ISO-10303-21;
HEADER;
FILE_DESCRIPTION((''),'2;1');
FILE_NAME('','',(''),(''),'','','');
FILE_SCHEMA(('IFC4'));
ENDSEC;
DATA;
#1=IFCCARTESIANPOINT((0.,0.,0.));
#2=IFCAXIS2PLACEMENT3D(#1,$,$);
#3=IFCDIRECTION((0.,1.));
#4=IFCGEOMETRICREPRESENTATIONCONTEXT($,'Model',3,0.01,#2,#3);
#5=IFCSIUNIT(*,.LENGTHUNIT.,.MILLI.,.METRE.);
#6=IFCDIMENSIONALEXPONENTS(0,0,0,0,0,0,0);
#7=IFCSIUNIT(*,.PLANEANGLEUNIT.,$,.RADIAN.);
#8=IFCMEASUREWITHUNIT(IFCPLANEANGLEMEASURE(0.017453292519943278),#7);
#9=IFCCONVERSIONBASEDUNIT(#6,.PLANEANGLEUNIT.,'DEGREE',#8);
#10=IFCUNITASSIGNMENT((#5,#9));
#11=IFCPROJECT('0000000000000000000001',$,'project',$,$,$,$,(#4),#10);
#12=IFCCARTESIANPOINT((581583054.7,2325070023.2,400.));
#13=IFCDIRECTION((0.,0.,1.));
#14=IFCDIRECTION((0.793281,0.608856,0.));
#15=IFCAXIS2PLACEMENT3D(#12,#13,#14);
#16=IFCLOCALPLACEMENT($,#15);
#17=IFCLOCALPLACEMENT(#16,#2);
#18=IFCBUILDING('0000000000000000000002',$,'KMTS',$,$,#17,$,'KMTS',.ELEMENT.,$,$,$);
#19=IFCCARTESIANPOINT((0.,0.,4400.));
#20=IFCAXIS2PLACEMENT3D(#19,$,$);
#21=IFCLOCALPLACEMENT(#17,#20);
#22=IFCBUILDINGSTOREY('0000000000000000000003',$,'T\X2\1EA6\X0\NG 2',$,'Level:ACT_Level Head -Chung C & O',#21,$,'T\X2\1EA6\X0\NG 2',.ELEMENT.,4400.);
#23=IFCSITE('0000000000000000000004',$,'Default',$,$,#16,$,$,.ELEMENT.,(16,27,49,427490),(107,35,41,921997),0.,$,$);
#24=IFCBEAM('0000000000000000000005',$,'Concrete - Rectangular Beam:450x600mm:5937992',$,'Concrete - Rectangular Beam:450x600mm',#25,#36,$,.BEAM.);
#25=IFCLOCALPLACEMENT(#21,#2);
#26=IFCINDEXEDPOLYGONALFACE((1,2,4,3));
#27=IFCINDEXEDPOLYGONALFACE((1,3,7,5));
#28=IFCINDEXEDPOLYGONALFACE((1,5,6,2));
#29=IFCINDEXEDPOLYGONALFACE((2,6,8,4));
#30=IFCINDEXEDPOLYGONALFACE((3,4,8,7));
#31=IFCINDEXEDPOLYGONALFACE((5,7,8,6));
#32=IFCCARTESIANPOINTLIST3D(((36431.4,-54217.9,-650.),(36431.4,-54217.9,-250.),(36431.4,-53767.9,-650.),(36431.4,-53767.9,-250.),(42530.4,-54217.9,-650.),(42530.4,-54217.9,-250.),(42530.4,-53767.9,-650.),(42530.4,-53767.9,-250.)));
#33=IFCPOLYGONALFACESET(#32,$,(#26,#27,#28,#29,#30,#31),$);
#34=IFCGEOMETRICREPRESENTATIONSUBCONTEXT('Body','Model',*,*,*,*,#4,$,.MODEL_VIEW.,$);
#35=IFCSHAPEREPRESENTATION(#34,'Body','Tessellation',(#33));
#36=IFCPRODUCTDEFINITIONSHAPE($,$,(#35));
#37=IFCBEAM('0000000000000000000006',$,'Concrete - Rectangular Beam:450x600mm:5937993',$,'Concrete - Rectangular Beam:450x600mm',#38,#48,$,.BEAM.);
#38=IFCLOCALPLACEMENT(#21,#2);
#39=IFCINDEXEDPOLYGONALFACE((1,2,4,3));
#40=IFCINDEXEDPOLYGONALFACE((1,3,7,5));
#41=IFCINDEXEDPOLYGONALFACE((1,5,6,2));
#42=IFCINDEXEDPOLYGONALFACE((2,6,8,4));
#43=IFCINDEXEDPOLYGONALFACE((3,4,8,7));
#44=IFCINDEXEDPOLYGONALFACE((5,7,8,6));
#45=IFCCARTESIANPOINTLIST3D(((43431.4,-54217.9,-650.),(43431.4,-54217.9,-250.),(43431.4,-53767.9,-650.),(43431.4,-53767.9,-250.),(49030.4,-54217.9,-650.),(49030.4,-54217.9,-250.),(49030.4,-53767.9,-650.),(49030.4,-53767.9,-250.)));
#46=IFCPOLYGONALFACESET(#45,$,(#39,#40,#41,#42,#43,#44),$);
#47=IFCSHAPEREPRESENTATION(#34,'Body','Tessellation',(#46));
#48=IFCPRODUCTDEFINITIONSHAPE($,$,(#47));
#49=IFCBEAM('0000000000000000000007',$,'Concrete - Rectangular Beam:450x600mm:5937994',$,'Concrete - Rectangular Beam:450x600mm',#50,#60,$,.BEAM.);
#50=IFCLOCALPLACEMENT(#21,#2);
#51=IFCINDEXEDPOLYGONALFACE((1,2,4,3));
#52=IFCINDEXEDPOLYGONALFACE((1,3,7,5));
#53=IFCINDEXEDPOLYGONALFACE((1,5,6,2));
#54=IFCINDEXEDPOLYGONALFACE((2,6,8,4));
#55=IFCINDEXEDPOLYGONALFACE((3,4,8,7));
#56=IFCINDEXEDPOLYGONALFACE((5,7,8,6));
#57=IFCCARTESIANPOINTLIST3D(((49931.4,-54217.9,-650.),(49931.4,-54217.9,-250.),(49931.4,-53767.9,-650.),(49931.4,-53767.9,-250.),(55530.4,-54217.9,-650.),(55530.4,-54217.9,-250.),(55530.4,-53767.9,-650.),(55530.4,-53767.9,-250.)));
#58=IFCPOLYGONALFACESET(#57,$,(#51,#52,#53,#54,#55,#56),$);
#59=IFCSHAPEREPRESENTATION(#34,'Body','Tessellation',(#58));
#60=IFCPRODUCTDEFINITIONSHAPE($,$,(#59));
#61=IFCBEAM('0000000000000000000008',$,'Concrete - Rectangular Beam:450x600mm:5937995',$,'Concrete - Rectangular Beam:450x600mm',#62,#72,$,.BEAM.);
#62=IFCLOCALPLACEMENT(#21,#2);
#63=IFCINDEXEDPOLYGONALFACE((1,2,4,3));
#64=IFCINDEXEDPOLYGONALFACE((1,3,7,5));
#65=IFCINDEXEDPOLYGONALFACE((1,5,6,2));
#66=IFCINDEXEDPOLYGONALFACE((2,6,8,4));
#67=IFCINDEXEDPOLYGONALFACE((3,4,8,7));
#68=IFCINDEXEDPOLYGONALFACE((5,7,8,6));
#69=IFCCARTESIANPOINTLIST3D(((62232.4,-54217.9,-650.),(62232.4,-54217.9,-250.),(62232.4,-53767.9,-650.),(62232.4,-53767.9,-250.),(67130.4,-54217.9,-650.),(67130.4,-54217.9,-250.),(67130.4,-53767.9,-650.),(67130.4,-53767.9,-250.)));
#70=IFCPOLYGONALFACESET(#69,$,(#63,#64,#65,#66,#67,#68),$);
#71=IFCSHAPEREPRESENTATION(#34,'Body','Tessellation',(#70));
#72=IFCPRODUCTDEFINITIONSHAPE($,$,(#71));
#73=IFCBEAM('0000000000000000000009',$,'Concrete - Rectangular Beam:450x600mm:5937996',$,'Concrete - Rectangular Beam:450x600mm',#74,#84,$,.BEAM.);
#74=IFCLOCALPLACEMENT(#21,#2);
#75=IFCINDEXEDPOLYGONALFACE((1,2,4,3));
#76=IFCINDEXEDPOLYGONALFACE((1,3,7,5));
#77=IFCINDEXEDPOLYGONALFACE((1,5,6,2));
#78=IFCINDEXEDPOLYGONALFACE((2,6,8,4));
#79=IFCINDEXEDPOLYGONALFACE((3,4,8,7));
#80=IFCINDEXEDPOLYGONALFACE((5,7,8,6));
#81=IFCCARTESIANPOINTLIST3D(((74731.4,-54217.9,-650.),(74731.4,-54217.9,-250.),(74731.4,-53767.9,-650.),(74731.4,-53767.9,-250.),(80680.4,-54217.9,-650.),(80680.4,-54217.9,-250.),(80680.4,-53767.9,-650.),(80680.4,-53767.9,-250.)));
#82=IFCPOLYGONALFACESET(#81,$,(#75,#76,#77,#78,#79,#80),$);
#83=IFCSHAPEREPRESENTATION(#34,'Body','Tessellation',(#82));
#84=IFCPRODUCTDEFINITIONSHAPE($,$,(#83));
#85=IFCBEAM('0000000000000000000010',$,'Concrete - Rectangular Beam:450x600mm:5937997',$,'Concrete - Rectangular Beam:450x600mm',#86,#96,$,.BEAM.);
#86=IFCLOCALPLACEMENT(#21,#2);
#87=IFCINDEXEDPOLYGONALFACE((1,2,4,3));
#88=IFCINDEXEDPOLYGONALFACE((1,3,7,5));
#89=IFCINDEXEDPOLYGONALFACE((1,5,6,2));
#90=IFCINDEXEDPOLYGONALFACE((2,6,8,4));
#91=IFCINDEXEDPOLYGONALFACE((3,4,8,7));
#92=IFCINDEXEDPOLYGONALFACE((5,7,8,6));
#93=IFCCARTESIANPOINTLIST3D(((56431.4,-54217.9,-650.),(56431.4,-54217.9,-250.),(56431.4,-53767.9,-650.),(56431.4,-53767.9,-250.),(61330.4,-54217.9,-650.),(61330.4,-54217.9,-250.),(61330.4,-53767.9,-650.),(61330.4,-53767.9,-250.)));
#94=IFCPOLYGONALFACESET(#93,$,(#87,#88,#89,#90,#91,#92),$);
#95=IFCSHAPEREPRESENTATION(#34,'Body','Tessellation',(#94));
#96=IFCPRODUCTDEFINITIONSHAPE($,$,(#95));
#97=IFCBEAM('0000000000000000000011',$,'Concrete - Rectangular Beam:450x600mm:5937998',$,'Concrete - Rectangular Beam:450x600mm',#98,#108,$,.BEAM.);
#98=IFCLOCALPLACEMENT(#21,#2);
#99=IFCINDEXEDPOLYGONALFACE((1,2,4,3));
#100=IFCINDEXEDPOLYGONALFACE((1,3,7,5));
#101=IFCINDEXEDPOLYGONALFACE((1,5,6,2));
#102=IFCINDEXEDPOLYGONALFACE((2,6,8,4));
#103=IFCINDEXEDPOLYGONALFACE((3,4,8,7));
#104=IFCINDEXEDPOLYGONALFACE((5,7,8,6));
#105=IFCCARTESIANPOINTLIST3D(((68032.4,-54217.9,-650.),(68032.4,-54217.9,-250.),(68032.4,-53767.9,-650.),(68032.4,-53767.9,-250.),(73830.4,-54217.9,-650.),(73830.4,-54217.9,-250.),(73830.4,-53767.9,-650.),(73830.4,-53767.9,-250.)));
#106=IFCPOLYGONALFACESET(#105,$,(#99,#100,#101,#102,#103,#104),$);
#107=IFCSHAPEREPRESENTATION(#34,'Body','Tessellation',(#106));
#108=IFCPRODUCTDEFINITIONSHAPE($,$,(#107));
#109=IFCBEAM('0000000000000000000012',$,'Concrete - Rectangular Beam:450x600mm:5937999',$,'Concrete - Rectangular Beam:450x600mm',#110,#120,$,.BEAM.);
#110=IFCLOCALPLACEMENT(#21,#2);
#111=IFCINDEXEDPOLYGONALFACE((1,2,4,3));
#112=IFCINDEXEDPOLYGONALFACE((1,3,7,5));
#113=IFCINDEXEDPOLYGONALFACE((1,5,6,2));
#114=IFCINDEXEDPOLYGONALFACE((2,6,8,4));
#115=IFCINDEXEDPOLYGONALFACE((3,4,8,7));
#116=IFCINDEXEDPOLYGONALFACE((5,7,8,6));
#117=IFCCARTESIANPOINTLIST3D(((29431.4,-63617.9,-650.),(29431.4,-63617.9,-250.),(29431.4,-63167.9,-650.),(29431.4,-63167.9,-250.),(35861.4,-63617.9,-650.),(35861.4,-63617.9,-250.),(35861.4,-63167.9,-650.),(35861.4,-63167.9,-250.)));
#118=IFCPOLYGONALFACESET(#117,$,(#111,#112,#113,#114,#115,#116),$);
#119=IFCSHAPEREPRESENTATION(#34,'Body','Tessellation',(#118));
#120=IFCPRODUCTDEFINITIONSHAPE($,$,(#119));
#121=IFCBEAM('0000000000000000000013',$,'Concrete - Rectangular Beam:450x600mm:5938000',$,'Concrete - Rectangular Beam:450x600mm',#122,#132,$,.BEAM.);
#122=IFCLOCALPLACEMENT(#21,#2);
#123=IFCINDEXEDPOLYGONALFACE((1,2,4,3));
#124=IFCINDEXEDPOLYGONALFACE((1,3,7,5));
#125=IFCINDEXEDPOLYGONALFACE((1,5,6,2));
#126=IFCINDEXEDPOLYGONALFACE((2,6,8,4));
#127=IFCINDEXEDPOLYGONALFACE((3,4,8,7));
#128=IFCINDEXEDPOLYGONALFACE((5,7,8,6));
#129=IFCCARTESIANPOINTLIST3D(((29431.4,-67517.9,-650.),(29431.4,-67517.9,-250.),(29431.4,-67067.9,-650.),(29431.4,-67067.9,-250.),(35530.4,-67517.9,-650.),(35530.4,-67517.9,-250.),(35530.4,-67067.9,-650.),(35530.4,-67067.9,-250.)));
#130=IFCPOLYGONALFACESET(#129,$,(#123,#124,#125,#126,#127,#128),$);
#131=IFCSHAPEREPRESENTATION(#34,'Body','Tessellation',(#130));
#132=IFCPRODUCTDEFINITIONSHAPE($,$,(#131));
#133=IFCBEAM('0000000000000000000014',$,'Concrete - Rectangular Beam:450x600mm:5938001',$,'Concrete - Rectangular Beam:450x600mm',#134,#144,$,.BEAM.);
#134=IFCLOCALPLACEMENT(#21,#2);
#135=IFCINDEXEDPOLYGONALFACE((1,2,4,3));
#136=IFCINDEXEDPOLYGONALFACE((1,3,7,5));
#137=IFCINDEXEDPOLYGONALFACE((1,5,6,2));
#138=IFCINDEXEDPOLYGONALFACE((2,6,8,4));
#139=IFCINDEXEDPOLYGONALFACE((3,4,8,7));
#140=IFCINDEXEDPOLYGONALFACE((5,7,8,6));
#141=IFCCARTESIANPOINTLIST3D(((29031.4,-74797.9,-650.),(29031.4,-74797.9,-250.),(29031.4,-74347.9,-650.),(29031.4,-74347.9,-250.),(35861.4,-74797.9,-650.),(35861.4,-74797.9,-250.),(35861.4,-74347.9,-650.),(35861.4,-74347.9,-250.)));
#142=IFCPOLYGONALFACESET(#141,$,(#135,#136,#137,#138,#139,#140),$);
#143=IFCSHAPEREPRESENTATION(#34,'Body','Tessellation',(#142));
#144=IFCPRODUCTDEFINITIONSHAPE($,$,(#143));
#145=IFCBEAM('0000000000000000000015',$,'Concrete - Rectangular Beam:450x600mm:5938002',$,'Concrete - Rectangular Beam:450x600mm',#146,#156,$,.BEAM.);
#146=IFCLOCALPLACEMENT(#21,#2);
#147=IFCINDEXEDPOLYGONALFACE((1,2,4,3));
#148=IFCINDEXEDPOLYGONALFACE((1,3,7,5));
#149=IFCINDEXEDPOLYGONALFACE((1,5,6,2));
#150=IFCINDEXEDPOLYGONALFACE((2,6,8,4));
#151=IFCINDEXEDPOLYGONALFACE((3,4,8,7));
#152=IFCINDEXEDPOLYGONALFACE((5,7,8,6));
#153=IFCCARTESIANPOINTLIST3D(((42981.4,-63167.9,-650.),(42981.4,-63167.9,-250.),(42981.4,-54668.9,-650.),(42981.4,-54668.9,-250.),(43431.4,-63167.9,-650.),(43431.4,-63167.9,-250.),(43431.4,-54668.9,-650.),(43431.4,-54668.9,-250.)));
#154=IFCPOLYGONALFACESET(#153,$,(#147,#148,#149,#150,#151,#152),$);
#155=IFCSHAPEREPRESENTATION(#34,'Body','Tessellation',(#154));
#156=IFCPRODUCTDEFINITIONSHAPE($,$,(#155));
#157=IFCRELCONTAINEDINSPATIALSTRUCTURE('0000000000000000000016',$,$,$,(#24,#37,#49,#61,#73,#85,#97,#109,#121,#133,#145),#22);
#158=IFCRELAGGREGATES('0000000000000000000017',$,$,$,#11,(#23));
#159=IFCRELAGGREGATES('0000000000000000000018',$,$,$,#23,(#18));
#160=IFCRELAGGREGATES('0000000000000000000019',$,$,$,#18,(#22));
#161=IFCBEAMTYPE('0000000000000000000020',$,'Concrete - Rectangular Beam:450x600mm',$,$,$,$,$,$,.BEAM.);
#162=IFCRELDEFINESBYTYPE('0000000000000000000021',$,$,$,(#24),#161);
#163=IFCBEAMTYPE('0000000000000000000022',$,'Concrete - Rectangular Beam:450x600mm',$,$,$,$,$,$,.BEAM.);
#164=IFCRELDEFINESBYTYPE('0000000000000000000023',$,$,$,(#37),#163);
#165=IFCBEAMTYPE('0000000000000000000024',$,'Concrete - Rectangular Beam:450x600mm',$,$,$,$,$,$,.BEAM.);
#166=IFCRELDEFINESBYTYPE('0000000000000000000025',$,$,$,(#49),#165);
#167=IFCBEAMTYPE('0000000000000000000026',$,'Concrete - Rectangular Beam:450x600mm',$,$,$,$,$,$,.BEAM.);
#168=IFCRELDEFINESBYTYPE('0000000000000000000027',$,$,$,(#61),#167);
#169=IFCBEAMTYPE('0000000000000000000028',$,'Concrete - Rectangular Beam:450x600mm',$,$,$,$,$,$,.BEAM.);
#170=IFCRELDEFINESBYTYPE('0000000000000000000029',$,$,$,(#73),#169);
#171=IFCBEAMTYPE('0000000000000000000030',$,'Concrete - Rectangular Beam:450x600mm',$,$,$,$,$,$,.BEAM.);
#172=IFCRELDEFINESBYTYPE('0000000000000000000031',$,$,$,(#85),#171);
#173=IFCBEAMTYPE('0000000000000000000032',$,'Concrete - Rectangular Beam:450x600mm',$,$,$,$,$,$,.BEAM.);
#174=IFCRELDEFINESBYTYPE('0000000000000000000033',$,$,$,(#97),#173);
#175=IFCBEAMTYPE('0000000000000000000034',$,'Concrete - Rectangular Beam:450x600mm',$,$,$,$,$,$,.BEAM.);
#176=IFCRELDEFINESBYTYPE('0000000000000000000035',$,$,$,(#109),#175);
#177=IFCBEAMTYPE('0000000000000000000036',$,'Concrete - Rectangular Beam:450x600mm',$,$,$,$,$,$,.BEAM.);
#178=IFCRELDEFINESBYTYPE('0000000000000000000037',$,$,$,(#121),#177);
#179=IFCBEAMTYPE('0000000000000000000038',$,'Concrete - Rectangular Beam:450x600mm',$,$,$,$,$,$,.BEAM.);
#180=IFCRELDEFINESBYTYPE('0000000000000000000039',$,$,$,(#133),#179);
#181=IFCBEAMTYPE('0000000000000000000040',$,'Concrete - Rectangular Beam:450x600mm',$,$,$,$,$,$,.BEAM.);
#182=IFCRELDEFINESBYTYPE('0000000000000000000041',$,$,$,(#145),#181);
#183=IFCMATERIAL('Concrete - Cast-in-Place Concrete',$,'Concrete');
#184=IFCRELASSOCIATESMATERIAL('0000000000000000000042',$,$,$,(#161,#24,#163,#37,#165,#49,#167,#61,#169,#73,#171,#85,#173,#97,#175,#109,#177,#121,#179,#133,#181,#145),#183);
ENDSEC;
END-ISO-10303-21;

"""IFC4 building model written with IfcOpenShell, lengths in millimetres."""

from ifc_helpers import new_model, entity, si_unit, converted_unit, direction, frame, origin, place, context, subcontext, project, spatial, indexed_curve, outline, extrude, source, transform, mapped, material, type_object, type_shapes, element, save


model = new_model("IFC4")

# Units and contexts
model_context = context("Model", 3, precision=0.01, world=origin(), true_north=direction((0.0, 1.0)))
body_context = subcontext(model_context, "Body", "Model", "MODEL_VIEW")
ifc_project = project(units=[si_unit("LENGTHUNIT", "METRE", prefix="MILLI"), converted_unit("PLANEANGLEUNIT", "DEGREE", entity("IfcPlaneAngleMeasure", 0.017453292519943278), si_unit("PLANEANGLEUNIT", "RADIAN"), dimensions=[0, 0, 0, 0, 0, 0, 0])], contexts=[model_context])

# Site, building, storey
site_placement = place(None, frame((581583054.7, 2325070023.2, 400.0), z_axis=(0.0, 0.0, 1.0), x_axis=(0.793281, 0.608856, 0.0)))
site = spatial("IfcSite", under=ifc_project, at=site_placement, Name="Default", CompositionType="ELEMENT", RefLatitude=(16, 27, 49, 427490), RefLongitude=(107, 35, 41, 921997), RefElevation=0.0)
building_placement = place(site_placement, origin())
building = spatial("IfcBuilding", under=site, at=building_placement, Name="KMTS", LongName="KMTS", CompositionType="ELEMENT")
storey_placement = place(building_placement, frame((0.0, 0.0, 4400.0)))
storey = spatial("IfcBuildingStorey", under=building, at=storey_placement, Name="TẦNG 2", ObjectType="Level:ACT_Level Head -Chung C & O", LongName="TẦNG 2", CompositionType="ELEMENT", Elevation=4400.0)

# Beams
ifc_material = material(Name="Concrete - Cast-in-Place Concrete", Category="Concrete")
beam_type_1 = type_object("IfcBeamType", Name="Concrete - Rectangular Beam:450x600mm", PredefinedType="BEAM", material=ifc_material)
shared_shape_1 = source(origin(), body_context, "Body", "SweptSolid", [
    extrude(outline(indexed_curve([(-200.0, -225.0), (200.0, -225.0), (200.0, 225.0), (-200.0, 225.0), (-200.0, -225.0)], self_intersect=False)), frame((36431.4, -53992.9, 3950.0), z_axis=(1.0, 0.0, 0.0), x_axis=(0.0, 0.0, -1.0)), (0.0, 0.0, 1.0), 6099.0),
])
type_shapes(beam_type_1, [shared_shape_1])
beam_1_placement = place(storey_placement, frame((0.0, 0.0, -4400.0)))
element("IfcBeam", 1, at=beam_1_placement, inside=storey, type_object=beam_type_1, material=ifc_material, Name="Concrete - Rectangular Beam:450x600mm:5937992", ObjectType="Concrete - Rectangular Beam:450x600mm", PredefinedType="BEAM", context=body_context, shape_type="MappedRepresentation", body=[
    mapped(shared_shape_1, transform((0.0, 0.0, 0.0), scale=1.0)),
])
beam_type_2 = type_object("IfcBeamType", Name="Concrete - Rectangular Beam:450x600mm", PredefinedType="BEAM", material=ifc_material)
shared_shape_2 = source(origin(), body_context, "Body", "SweptSolid", [
    extrude(outline(indexed_curve([(-200.0, -225.0), (200.0, -225.0), (200.0, 225.0), (-200.0, 225.0), (-200.0, -225.0)], self_intersect=False)), frame((43431.4, -53992.9, 3950.0), z_axis=(1.0, 0.0, 0.0), x_axis=(0.0, 0.0, -1.0)), (0.0, 0.0, 1.0), 5599.0),
])
type_shapes(beam_type_2, [shared_shape_2])
beam_2_placement = place(storey_placement, frame((0.0, 0.0, -4400.0)))
element("IfcBeam", 2, at=beam_2_placement, inside=storey, type_object=beam_type_2, material=ifc_material, Name="Concrete - Rectangular Beam:450x600mm:5937993", ObjectType="Concrete - Rectangular Beam:450x600mm", PredefinedType="BEAM", context=body_context, shape_type="MappedRepresentation", body=[
    mapped(shared_shape_2, transform((0.0, 0.0, 0.0), scale=1.0)),
])
beam_type_3 = type_object("IfcBeamType", Name="Concrete - Rectangular Beam:450x600mm", PredefinedType="BEAM", material=ifc_material)
shared_shape_3 = source(origin(), body_context, "Body", "SweptSolid", [
    extrude(outline(indexed_curve([(-200.0, -225.0), (200.0, -225.0), (200.0, 225.0), (-200.0, 225.0), (-200.0, -225.0)], self_intersect=False)), frame((49931.4, -53992.9, 3950.0), z_axis=(1.0, 0.0, 0.0), x_axis=(0.0, 0.0, -1.0)), (0.0, 0.0, 1.0), 5599.0),
])
type_shapes(beam_type_3, [shared_shape_3])
beam_3_placement = place(storey_placement, frame((0.0, 0.0, -4400.0)))
element("IfcBeam", 3, at=beam_3_placement, inside=storey, type_object=beam_type_3, material=ifc_material, Name="Concrete - Rectangular Beam:450x600mm:5937994", ObjectType="Concrete - Rectangular Beam:450x600mm", PredefinedType="BEAM", context=body_context, shape_type="MappedRepresentation", body=[
    mapped(shared_shape_3, transform((0.0, 0.0, 0.0), scale=1.0)),
])
beam_type_4 = type_object("IfcBeamType", Name="Concrete - Rectangular Beam:450x600mm", PredefinedType="BEAM", material=ifc_material)
shared_shape_4 = source(origin(), body_context, "Body", "SweptSolid", [
    extrude(outline(indexed_curve([(-200.0, -225.0), (200.0, -225.0), (200.0, 225.0), (-200.0, 225.0), (-200.0, -225.0)], self_intersect=False)), frame((62232.4, -53992.9, 3950.0), z_axis=(1.0, 0.0, 0.0), x_axis=(0.0, 0.0, -1.0)), (0.0, 0.0, 1.0), 4898.0),
])
type_shapes(beam_type_4, [shared_shape_4])
beam_4_placement = place(storey_placement, frame((0.0, 0.0, -4400.0)))
element("IfcBeam", 4, at=beam_4_placement, inside=storey, type_object=beam_type_4, material=ifc_material, Name="Concrete - Rectangular Beam:450x600mm:5937995", ObjectType="Concrete - Rectangular Beam:450x600mm", PredefinedType="BEAM", context=body_context, shape_type="MappedRepresentation", body=[
    mapped(shared_shape_4, transform((0.0, 0.0, 0.0), scale=1.0)),
])
beam_type_5 = type_object("IfcBeamType", Name="Concrete - Rectangular Beam:450x600mm", PredefinedType="BEAM", material=ifc_material)
shared_shape_5 = source(origin(), body_context, "Body", "SweptSolid", [
    extrude(outline(indexed_curve([(-200.0, -225.0), (200.0, -225.0), (200.0, 225.0), (-200.0, 225.0), (-200.0, -225.0)], self_intersect=False)), frame((74731.4, -53992.9, 3950.0), z_axis=(1.0, 0.0, 0.0), x_axis=(0.0, 0.0, -1.0)), (0.0, 0.0, 1.0), 5949.0),
])
type_shapes(beam_type_5, [shared_shape_5])
beam_5_placement = place(storey_placement, frame((0.0, 0.0, -4400.0)))
element("IfcBeam", 5, at=beam_5_placement, inside=storey, type_object=beam_type_5, material=ifc_material, Name="Concrete - Rectangular Beam:450x600mm:5937996", ObjectType="Concrete - Rectangular Beam:450x600mm", PredefinedType="BEAM", context=body_context, shape_type="MappedRepresentation", body=[
    mapped(shared_shape_5, transform((0.0, 0.0, 0.0), scale=1.0)),
])
beam_type_6 = type_object("IfcBeamType", Name="Concrete - Rectangular Beam:450x600mm", PredefinedType="BEAM", material=ifc_material)
shared_shape_6 = source(origin(), body_context, "Body", "SweptSolid", [
    extrude(outline(indexed_curve([(-200.0, -225.0), (200.0, -225.0), (200.0, 225.0), (-200.0, 225.0), (-200.0, -225.0)], self_intersect=False)), frame((56431.4, -53992.9, 3950.0), z_axis=(1.0, 0.0, 0.0), x_axis=(0.0, 0.0, -1.0)), (0.0, 0.0, 1.0), 4899.0),
])
type_shapes(beam_type_6, [shared_shape_6])
beam_6_placement = place(storey_placement, frame((0.0, 0.0, -4400.0)))
element("IfcBeam", 6, at=beam_6_placement, inside=storey, type_object=beam_type_6, material=ifc_material, Name="Concrete - Rectangular Beam:450x600mm:5937997", ObjectType="Concrete - Rectangular Beam:450x600mm", PredefinedType="BEAM", context=body_context, shape_type="MappedRepresentation", body=[
    mapped(shared_shape_6, transform((0.0, 0.0, 0.0), scale=1.0)),
])
beam_type_7 = type_object("IfcBeamType", Name="Concrete - Rectangular Beam:450x600mm", PredefinedType="BEAM", material=ifc_material)
shared_shape_7 = source(origin(), body_context, "Body", "SweptSolid", [
    extrude(outline(indexed_curve([(-200.0, -225.0), (200.0, -225.0), (200.0, 225.0), (-200.0, 225.0), (-200.0, -225.0)], self_intersect=False)), frame((68032.4, -53992.9, 3950.0), z_axis=(1.0, 0.0, 0.0), x_axis=(0.0, 0.0, -1.0)), (0.0, 0.0, 1.0), 5798.0),
])
type_shapes(beam_type_7, [shared_shape_7])
beam_7_placement = place(storey_placement, frame((0.0, 0.0, -4400.0)))
element("IfcBeam", 7, at=beam_7_placement, inside=storey, type_object=beam_type_7, material=ifc_material, Name="Concrete - Rectangular Beam:450x600mm:5937998", ObjectType="Concrete - Rectangular Beam:450x600mm", PredefinedType="BEAM", context=body_context, shape_type="MappedRepresentation", body=[
    mapped(shared_shape_7, transform((0.0, 0.0, 0.0), scale=1.0)),
])
beam_type_8 = type_object("IfcBeamType", Name="Concrete - Rectangular Beam:450x600mm", PredefinedType="BEAM", material=ifc_material)
shared_shape_8 = source(origin(), body_context, "Body", "SweptSolid", [
    extrude(outline(indexed_curve([(-200.0, -225.0), (200.0, -225.0), (200.0, 225.0), (-200.0, 225.0), (-200.0, -225.0)], self_intersect=False)), frame((29431.4, -63392.9, 3950.0), z_axis=(1.0, 0.0, 0.0), x_axis=(0.0, 0.0, -1.0)), (0.0, 0.0, 1.0), 6430.0),
])
type_shapes(beam_type_8, [shared_shape_8])
beam_8_placement = place(storey_placement, frame((0.0, 0.0, -4400.0)))
element("IfcBeam", 8, at=beam_8_placement, inside=storey, type_object=beam_type_8, material=ifc_material, Name="Concrete - Rectangular Beam:450x600mm:5937999", ObjectType="Concrete - Rectangular Beam:450x600mm", PredefinedType="BEAM", context=body_context, shape_type="MappedRepresentation", body=[
    mapped(shared_shape_8, transform((0.0, 0.0, 0.0), scale=1.0)),
])
beam_type_9 = type_object("IfcBeamType", Name="Concrete - Rectangular Beam:450x600mm", PredefinedType="BEAM", material=ifc_material)
shared_shape_9 = source(origin(), body_context, "Body", "SweptSolid", [
    extrude(outline(indexed_curve([(-200.0, -225.0), (200.0, -225.0), (200.0, 225.0), (-200.0, 225.0), (-200.0, -225.0)], self_intersect=False)), frame((29431.4, -67292.9, 3950.0), z_axis=(1.0, 0.0, 0.0), x_axis=(0.0, 0.0, -1.0)), (0.0, 0.0, 1.0), 6099.0),
])
type_shapes(beam_type_9, [shared_shape_9])
beam_9_placement = place(storey_placement, frame((0.0, 0.0, -4400.0)))
element("IfcBeam", 9, at=beam_9_placement, inside=storey, type_object=beam_type_9, material=ifc_material, Name="Concrete - Rectangular Beam:450x600mm:5938000", ObjectType="Concrete - Rectangular Beam:450x600mm", PredefinedType="BEAM", context=body_context, shape_type="MappedRepresentation", body=[
    mapped(shared_shape_9, transform((0.0, 0.0, 0.0), scale=1.0)),
])
beam_type_10 = type_object("IfcBeamType", Name="Concrete - Rectangular Beam:450x600mm", PredefinedType="BEAM", material=ifc_material)
shared_shape_10 = source(origin(), body_context, "Body", "SweptSolid", [
    extrude(outline(indexed_curve([(-200.0, -225.0), (200.0, -225.0), (200.0, 225.0), (-200.0, 225.0), (-200.0, -225.0)], self_intersect=False)), frame((29031.4, -74572.9, 3950.0), z_axis=(1.0, 0.0, 0.0), x_axis=(0.0, 0.0, -1.0)), (0.0, 0.0, 1.0), 6830.0),
])
type_shapes(beam_type_10, [shared_shape_10])
beam_10_placement = place(storey_placement, frame((0.0, 0.0, -4400.0)))
element("IfcBeam", 10, at=beam_10_placement, inside=storey, type_object=beam_type_10, material=ifc_material, Name="Concrete - Rectangular Beam:450x600mm:5938001", ObjectType="Concrete - Rectangular Beam:450x600mm", PredefinedType="BEAM", context=body_context, shape_type="MappedRepresentation", body=[
    mapped(shared_shape_10, transform((0.0, 0.0, 0.0), scale=1.0)),
])
beam_type_11 = type_object("IfcBeamType", Name="Concrete - Rectangular Beam:450x600mm", PredefinedType="BEAM", material=ifc_material)
shared_shape_11 = source(origin(), body_context, "Body", "SweptSolid", [
    extrude(outline(indexed_curve([(-225.0, -200.0), (225.0, -200.0), (225.0, 200.0), (-225.0, 200.0), (-225.0, -200.0)], self_intersect=False)), frame((43206.4, -54668.9, 3950.0), z_axis=(0.0, -1.0, 0.0), x_axis=(-1.0, 0.0, 0.0)), (0.0, 0.0, 1.0), 8499.0),
])
type_shapes(beam_type_11, [shared_shape_11])
beam_11_placement = place(storey_placement, frame((0.0, 0.0, -4400.0)))
element("IfcBeam", 11, at=beam_11_placement, inside=storey, type_object=beam_type_11, material=ifc_material, Name="Concrete - Rectangular Beam:450x600mm:5938002", ObjectType="Concrete - Rectangular Beam:450x600mm", PredefinedType="BEAM", context=body_context, shape_type="MappedRepresentation", body=[
    mapped(shared_shape_11, transform((0.0, 0.0, 0.0), scale=1.0)),
])

save(model, "model.ifc")
